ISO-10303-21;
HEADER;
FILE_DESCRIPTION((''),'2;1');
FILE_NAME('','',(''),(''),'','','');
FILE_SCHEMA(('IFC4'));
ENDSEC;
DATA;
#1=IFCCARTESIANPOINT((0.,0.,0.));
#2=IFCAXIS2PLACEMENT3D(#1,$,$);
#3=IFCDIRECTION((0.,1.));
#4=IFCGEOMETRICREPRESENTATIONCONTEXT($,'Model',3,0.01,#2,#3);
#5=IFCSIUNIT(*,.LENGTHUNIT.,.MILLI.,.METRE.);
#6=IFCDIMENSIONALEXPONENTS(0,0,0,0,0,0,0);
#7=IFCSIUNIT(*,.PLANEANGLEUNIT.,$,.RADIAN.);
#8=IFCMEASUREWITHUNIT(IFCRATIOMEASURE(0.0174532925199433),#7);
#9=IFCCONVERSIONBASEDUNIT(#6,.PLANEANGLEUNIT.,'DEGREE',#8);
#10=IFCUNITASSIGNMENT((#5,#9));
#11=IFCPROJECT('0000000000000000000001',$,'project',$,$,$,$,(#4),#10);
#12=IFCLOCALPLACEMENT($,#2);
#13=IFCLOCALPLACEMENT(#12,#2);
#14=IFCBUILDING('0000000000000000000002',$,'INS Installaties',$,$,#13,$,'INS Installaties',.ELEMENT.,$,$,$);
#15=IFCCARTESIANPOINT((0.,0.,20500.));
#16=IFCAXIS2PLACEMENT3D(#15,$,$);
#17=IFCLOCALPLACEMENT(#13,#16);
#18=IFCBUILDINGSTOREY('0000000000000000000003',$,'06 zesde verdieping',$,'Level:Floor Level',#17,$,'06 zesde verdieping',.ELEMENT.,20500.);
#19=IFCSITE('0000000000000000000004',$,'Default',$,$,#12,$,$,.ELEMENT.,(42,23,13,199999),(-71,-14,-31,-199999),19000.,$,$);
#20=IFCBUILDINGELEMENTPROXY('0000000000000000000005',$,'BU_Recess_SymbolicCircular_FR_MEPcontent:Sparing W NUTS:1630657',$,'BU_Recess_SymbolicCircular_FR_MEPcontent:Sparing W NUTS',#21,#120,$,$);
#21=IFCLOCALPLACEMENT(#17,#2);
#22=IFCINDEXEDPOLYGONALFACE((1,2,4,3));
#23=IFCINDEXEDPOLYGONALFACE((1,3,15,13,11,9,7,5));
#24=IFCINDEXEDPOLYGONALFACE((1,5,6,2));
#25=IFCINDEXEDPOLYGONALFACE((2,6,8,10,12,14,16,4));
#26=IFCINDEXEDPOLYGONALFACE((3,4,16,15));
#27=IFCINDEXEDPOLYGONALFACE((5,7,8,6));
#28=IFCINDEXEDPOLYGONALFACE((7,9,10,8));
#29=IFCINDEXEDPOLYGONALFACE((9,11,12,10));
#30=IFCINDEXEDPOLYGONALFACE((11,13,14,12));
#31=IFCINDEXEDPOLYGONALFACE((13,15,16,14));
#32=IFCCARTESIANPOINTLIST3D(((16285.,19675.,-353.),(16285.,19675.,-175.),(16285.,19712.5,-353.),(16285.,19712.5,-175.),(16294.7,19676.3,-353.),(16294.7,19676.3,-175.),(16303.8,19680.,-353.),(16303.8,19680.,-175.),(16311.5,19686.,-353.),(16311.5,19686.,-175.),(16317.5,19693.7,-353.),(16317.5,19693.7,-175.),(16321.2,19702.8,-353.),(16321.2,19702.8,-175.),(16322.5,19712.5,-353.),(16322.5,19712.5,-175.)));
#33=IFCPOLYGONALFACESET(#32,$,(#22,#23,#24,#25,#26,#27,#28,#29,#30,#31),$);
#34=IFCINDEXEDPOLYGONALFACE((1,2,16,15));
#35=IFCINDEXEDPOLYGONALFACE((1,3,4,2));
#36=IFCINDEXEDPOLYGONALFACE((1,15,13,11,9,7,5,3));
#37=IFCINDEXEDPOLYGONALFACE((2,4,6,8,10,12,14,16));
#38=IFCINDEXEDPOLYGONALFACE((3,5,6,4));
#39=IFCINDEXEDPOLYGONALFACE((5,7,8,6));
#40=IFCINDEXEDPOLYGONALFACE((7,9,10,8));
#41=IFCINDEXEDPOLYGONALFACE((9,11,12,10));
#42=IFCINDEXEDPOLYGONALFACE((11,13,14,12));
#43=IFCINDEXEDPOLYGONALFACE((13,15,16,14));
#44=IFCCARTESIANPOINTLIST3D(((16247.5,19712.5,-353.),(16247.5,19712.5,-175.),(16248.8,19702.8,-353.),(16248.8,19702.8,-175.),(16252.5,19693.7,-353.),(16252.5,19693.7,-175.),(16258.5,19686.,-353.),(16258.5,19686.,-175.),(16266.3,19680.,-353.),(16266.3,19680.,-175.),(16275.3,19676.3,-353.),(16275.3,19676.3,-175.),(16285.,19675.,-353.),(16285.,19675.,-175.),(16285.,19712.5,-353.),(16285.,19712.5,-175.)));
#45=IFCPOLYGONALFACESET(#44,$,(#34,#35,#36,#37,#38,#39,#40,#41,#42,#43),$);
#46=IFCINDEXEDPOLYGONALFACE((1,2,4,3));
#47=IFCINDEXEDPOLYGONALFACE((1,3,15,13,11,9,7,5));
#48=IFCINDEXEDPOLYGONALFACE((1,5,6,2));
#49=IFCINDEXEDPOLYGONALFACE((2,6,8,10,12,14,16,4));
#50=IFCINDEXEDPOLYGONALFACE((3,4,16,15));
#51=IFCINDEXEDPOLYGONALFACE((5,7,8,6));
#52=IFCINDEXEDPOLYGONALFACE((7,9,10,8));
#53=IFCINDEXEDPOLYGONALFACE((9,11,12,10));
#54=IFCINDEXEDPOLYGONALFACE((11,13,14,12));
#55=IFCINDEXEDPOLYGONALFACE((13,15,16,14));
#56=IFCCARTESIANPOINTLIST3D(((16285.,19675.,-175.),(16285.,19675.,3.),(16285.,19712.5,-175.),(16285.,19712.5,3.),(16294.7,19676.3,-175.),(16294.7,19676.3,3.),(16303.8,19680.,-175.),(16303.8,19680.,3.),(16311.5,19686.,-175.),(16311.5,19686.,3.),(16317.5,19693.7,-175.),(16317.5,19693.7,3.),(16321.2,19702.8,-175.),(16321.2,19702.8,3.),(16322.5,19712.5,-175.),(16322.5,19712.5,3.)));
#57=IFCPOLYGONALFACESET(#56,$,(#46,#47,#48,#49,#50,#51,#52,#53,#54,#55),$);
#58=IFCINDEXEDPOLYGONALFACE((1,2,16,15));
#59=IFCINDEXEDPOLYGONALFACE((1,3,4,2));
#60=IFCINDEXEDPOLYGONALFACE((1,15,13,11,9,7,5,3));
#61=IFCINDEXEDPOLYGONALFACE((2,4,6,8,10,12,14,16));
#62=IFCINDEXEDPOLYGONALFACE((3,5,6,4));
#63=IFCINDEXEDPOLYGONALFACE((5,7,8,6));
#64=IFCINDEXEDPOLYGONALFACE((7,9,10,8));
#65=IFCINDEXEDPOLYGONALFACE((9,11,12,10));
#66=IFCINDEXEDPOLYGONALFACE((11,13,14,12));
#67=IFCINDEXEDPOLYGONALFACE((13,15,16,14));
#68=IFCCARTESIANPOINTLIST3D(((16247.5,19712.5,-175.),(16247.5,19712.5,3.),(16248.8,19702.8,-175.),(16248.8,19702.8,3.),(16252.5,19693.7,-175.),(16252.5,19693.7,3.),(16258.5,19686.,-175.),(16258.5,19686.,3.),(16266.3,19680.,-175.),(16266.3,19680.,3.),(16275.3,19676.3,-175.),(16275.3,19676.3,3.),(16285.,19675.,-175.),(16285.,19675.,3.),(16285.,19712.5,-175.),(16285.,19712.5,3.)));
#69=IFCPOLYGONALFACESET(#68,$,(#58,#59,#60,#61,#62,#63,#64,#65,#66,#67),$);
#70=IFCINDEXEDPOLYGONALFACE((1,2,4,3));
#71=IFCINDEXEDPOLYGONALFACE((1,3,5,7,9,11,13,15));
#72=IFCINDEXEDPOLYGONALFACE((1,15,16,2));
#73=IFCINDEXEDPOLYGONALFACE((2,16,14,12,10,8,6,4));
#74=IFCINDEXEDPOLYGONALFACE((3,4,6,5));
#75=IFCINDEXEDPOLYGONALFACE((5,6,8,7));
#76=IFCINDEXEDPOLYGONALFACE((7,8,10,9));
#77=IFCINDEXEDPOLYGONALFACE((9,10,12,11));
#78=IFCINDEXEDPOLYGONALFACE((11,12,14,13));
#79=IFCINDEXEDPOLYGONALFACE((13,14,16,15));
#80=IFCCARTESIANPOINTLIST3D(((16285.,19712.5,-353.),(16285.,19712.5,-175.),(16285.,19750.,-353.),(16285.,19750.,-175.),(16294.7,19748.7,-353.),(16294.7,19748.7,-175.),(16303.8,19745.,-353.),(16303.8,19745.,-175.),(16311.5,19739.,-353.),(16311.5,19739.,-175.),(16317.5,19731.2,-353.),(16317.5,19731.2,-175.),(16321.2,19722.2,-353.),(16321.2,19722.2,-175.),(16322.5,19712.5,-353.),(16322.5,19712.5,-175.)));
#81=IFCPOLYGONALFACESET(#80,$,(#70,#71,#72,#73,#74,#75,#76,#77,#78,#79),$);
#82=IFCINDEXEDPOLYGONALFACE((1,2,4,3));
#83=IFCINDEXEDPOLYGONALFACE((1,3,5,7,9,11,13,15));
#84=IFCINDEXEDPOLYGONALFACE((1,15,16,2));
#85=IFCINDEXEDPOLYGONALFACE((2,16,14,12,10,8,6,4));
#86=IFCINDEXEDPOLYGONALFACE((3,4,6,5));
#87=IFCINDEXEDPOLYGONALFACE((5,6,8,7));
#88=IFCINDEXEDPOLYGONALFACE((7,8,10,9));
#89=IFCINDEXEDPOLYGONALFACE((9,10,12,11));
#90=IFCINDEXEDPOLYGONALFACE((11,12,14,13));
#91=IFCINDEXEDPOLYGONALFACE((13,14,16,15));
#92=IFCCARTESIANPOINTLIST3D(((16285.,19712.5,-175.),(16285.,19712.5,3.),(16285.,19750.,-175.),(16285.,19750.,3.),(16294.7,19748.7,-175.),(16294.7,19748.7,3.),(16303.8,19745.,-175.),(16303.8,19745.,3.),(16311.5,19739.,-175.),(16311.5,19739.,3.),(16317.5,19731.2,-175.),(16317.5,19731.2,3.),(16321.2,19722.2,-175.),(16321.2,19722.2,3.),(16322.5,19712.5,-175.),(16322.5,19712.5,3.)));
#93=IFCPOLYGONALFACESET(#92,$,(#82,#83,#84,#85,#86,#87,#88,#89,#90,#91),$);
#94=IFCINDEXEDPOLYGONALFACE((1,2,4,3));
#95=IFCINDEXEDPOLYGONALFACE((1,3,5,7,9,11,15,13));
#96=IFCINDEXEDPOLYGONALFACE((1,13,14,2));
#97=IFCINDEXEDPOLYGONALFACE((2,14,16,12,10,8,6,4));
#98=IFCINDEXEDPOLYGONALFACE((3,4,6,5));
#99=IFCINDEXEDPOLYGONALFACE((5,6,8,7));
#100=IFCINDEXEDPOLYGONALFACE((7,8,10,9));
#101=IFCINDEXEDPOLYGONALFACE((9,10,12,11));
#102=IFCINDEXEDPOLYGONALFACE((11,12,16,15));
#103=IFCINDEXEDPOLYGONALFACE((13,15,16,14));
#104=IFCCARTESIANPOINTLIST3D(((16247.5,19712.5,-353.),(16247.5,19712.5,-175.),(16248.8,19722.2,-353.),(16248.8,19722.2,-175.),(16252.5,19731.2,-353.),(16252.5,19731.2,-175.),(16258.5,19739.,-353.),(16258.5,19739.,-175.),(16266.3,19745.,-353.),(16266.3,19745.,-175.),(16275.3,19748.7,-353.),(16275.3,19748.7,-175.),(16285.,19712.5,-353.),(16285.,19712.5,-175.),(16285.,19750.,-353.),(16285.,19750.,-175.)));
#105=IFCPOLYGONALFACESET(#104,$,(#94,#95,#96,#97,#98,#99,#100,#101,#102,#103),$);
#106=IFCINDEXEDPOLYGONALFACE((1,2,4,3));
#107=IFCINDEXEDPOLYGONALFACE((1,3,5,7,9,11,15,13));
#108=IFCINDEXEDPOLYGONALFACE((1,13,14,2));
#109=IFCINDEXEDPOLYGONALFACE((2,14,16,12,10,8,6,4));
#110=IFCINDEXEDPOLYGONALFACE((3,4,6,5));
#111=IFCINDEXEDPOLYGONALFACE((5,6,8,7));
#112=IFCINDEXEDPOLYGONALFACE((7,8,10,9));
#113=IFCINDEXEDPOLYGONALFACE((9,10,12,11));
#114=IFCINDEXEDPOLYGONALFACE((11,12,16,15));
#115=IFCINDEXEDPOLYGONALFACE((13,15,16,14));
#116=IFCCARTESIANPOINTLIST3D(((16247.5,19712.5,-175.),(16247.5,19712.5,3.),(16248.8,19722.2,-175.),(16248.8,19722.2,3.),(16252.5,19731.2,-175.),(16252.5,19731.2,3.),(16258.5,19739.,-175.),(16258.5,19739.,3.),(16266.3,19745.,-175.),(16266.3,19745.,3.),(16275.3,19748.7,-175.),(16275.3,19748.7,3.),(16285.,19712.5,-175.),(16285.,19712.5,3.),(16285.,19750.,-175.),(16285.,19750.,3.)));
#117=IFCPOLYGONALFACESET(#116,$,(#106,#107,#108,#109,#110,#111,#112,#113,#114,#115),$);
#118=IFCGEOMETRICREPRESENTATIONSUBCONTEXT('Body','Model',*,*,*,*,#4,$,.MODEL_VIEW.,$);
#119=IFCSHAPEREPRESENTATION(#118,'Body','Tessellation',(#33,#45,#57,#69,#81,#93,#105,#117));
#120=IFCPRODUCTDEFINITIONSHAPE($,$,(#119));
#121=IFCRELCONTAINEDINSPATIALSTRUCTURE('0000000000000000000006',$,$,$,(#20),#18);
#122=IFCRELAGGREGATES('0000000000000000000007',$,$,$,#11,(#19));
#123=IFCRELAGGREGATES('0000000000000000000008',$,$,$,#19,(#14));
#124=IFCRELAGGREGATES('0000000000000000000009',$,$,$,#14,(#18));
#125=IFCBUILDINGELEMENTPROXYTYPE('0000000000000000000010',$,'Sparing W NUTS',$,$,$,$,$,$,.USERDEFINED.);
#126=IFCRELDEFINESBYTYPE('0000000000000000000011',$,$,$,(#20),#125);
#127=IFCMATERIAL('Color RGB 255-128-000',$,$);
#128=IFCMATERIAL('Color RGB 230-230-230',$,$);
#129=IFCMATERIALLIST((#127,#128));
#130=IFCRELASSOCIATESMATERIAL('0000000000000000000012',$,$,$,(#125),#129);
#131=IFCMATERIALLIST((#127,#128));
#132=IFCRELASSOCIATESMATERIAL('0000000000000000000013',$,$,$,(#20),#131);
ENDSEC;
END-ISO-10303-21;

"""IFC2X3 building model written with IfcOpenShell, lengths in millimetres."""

from ifc_helpers import new_model, entity, si_unit, converted_unit, direction, frame, frame_2d, origin, place, context, subcontext, project, spatial, polyline, circle_curve, parameter, trimmed, segment, composite_curve, outline, extrude, source, transform, mapped, material, material_list, type_object, type_shapes, element, save


model = new_model("IFC2X3")

# Units and contexts
model_context = context("Model", 3, precision=0.01, world=origin(), true_north=direction((0.0, 1.0)))
body_context = subcontext(model_context, "Body", "Model", "MODEL_VIEW")
ifc_project = project(units=[si_unit("LENGTHUNIT", "METRE", prefix="MILLI"), converted_unit("PLANEANGLEUNIT", "DEGREE", entity("IfcRatioMeasure", 0.0174532925199433), si_unit("PLANEANGLEUNIT", "RADIAN"), dimensions=[0, 0, 0, 0, 0, 0, 0])], contexts=[model_context])

# Site, building, storey
site_placement = place(None, origin())
site = spatial("IfcSite", under=ifc_project, at=site_placement, Name="Default", CompositionType="ELEMENT", RefLatitude=(42, 23, 13, 199999), RefLongitude=(-71, -14, -31, -199999), RefElevation=19000.0)
building_placement = place(site_placement, origin())
building = spatial("IfcBuilding", under=site, at=building_placement, Name="INS Installaties", LongName="INS Installaties", CompositionType="ELEMENT")
storey_placement = place(building_placement, frame((0.0, 0.0, 20500.0)))
storey = spatial("IfcBuildingStorey", under=building, at=storey_placement, Name="06 zesde verdieping", ObjectType="Level:Floor Level", LongName="06 zesde verdieping", CompositionType="ELEMENT", Elevation=20500.0)

# Building element proxy
ifc_material_1 = material(Name="Color RGB 255-128-000")
ifc_material_2 = material(Name="Color RGB 230-230-230")
ifc_material_list_1 = material_list([ifc_material_1, ifc_material_2])
ifc_material_list_2 = material_list([ifc_material_1, ifc_material_2])
building_element_proxy_type_1 = type_object("IfcBuildingElementProxyType", Name="Sparing W NUTS", PredefinedType="USERDEFINED", material=ifc_material_list_2)
shared_shape_1 = source(origin(), body_context, "Body", "SweptSolid", [
    extrude(outline(composite_curve([segment(polyline([(-25.0, -12.5), (12.5, -12.5)]), True, "CONTINUOUS"), segment(polyline([(12.5, -12.5), (12.5, 25.0)]), True, "CONTINUOUS"), segment(trimmed(circle_curve(frame_2d((12.5, -12.5), x_axis=(1.0, 0.0)), 37.5), [parameter(90.0)], [parameter(180.0)], True, "PARAMETER"), True, "CONTINUOUS")], self_intersect=False)), frame((12.5, -12.5, -353.0), z_axis=(0.0, 0.0, 1.0), x_axis=(-1.0, 0.0, 0.0)), (0.0, 0.0, 1.0), 178.0),
    extrude(outline(composite_curve([segment(trimmed(circle_curve(frame_2d((12.5, 12.5), x_axis=(1.0, 0.0)), 37.5), [parameter(180.0)], [parameter(270.0)], True, "PARAMETER"), True, "CONTINUOUS"), segment(polyline([(12.5, -25.0), (12.5, 12.5)]), True, "CONTINUOUS"), segment(polyline([(12.5, 12.5), (-25.0, 12.5)]), True, "CONTINUOUS")], self_intersect=False)), frame((-12.5, -12.5, -353.0)), (0.0, 0.0, 1.0), 178.0),
    extrude(outline(composite_curve([segment(polyline([(-25.0, -12.5), (12.5, -12.5)]), True, "CONTINUOUS"), segment(polyline([(12.5, -12.5), (12.5, 25.0)]), True, "CONTINUOUS"), segment(trimmed(circle_curve(frame_2d((12.5, -12.5), x_axis=(1.0, 0.0)), 37.5), [parameter(90.0)], [parameter(180.0)], True, "PARAMETER"), True, "CONTINUOUS")], self_intersect=False)), frame((12.5, -12.5, -175.0), z_axis=(0.0, 0.0, 1.0), x_axis=(-1.0, 0.0, 0.0)), (0.0, 0.0, 1.0), 178.0),
    extrude(outline(composite_curve([segment(trimmed(circle_curve(frame_2d((12.5, 12.5), x_axis=(1.0, 0.0)), 37.5), [parameter(180.0)], [parameter(270.0)], True, "PARAMETER"), True, "CONTINUOUS"), segment(polyline([(12.5, -25.0), (12.5, 12.5)]), True, "CONTINUOUS"), segment(polyline([(12.5, 12.5), (-25.0, 12.5)]), True, "CONTINUOUS")], self_intersect=False)), frame((-12.5, -12.5, -175.0)), (0.0, 0.0, 1.0), 178.0),
    extrude(outline(composite_curve([segment(trimmed(circle_curve(frame_2d((12.5, 12.5), x_axis=(1.0, 0.0)), 37.5), [parameter(180.0)], [parameter(270.0)], True, "PARAMETER"), True, "CONTINUOUS"), segment(polyline([(12.5, -25.0), (12.5, 12.5)]), True, "CONTINUOUS"), segment(polyline([(12.5, 12.5), (-25.0, 12.5)]), True, "CONTINUOUS")], self_intersect=False)), frame((12.5, 12.5, -353.0), z_axis=(0.0, 0.0, 1.0), x_axis=(-1.0, 0.0, 0.0)), (0.0, 0.0, 1.0), 178.0),
    extrude(outline(composite_curve([segment(trimmed(circle_curve(frame_2d((12.5, 12.5), x_axis=(1.0, 0.0)), 37.5), [parameter(180.0)], [parameter(270.0)], True, "PARAMETER"), True, "CONTINUOUS"), segment(polyline([(12.5, -25.0), (12.5, 12.5)]), True, "CONTINUOUS"), segment(polyline([(12.5, 12.5), (-25.0, 12.5)]), True, "CONTINUOUS")], self_intersect=False)), frame((12.5, 12.5, -175.0), z_axis=(0.0, 0.0, 1.0), x_axis=(-1.0, 0.0, 0.0)), (0.0, 0.0, 1.0), 178.0),
    extrude(outline(composite_curve([segment(polyline([(-25.0, -12.5), (12.5, -12.5)]), True, "CONTINUOUS"), segment(polyline([(12.5, -12.5), (12.5, 25.0)]), True, "CONTINUOUS"), segment(trimmed(circle_curve(frame_2d((12.5, -12.5), x_axis=(1.0, 0.0)), 37.5), [parameter(90.0)], [parameter(180.0)], True, "PARAMETER"), True, "CONTINUOUS")], self_intersect=False)), frame((-12.5, 12.5, -353.0)), (0.0, 0.0, 1.0), 178.0),
    extrude(outline(composite_curve([segment(polyline([(-25.0, -12.5), (12.5, -12.5)]), True, "CONTINUOUS"), segment(polyline([(12.5, -12.5), (12.5, 25.0)]), True, "CONTINUOUS"), segment(trimmed(circle_curve(frame_2d((12.5, -12.5), x_axis=(1.0, 0.0)), 37.5), [parameter(90.0)], [parameter(180.0)], True, "PARAMETER"), True, "CONTINUOUS")], self_intersect=False)), frame((-12.5, 12.5, -175.0)), (0.0, 0.0, 1.0), 178.0),
])
type_shapes(building_element_proxy_type_1, [shared_shape_1])
proxy_1_placement = place(storey_placement, frame((16285.0, 19712.5, 0.0)))
element("IfcBuildingElementProxy", 1, at=proxy_1_placement, inside=storey, type_object=building_element_proxy_type_1, material=ifc_material_list_1, Name="BU_Recess_SymbolicCircular_FR_MEPcontent:Sparing W NUTS:1630657", ObjectType="BU_Recess_SymbolicCircular_FR_MEPcontent:Sparing W NUTS", context=body_context, shape_type="MappedRepresentation", body=[
    mapped(shared_shape_1, transform((0.0, 0.0, 0.0), scale=1.0)),
])

save(model, "model.ifc")
